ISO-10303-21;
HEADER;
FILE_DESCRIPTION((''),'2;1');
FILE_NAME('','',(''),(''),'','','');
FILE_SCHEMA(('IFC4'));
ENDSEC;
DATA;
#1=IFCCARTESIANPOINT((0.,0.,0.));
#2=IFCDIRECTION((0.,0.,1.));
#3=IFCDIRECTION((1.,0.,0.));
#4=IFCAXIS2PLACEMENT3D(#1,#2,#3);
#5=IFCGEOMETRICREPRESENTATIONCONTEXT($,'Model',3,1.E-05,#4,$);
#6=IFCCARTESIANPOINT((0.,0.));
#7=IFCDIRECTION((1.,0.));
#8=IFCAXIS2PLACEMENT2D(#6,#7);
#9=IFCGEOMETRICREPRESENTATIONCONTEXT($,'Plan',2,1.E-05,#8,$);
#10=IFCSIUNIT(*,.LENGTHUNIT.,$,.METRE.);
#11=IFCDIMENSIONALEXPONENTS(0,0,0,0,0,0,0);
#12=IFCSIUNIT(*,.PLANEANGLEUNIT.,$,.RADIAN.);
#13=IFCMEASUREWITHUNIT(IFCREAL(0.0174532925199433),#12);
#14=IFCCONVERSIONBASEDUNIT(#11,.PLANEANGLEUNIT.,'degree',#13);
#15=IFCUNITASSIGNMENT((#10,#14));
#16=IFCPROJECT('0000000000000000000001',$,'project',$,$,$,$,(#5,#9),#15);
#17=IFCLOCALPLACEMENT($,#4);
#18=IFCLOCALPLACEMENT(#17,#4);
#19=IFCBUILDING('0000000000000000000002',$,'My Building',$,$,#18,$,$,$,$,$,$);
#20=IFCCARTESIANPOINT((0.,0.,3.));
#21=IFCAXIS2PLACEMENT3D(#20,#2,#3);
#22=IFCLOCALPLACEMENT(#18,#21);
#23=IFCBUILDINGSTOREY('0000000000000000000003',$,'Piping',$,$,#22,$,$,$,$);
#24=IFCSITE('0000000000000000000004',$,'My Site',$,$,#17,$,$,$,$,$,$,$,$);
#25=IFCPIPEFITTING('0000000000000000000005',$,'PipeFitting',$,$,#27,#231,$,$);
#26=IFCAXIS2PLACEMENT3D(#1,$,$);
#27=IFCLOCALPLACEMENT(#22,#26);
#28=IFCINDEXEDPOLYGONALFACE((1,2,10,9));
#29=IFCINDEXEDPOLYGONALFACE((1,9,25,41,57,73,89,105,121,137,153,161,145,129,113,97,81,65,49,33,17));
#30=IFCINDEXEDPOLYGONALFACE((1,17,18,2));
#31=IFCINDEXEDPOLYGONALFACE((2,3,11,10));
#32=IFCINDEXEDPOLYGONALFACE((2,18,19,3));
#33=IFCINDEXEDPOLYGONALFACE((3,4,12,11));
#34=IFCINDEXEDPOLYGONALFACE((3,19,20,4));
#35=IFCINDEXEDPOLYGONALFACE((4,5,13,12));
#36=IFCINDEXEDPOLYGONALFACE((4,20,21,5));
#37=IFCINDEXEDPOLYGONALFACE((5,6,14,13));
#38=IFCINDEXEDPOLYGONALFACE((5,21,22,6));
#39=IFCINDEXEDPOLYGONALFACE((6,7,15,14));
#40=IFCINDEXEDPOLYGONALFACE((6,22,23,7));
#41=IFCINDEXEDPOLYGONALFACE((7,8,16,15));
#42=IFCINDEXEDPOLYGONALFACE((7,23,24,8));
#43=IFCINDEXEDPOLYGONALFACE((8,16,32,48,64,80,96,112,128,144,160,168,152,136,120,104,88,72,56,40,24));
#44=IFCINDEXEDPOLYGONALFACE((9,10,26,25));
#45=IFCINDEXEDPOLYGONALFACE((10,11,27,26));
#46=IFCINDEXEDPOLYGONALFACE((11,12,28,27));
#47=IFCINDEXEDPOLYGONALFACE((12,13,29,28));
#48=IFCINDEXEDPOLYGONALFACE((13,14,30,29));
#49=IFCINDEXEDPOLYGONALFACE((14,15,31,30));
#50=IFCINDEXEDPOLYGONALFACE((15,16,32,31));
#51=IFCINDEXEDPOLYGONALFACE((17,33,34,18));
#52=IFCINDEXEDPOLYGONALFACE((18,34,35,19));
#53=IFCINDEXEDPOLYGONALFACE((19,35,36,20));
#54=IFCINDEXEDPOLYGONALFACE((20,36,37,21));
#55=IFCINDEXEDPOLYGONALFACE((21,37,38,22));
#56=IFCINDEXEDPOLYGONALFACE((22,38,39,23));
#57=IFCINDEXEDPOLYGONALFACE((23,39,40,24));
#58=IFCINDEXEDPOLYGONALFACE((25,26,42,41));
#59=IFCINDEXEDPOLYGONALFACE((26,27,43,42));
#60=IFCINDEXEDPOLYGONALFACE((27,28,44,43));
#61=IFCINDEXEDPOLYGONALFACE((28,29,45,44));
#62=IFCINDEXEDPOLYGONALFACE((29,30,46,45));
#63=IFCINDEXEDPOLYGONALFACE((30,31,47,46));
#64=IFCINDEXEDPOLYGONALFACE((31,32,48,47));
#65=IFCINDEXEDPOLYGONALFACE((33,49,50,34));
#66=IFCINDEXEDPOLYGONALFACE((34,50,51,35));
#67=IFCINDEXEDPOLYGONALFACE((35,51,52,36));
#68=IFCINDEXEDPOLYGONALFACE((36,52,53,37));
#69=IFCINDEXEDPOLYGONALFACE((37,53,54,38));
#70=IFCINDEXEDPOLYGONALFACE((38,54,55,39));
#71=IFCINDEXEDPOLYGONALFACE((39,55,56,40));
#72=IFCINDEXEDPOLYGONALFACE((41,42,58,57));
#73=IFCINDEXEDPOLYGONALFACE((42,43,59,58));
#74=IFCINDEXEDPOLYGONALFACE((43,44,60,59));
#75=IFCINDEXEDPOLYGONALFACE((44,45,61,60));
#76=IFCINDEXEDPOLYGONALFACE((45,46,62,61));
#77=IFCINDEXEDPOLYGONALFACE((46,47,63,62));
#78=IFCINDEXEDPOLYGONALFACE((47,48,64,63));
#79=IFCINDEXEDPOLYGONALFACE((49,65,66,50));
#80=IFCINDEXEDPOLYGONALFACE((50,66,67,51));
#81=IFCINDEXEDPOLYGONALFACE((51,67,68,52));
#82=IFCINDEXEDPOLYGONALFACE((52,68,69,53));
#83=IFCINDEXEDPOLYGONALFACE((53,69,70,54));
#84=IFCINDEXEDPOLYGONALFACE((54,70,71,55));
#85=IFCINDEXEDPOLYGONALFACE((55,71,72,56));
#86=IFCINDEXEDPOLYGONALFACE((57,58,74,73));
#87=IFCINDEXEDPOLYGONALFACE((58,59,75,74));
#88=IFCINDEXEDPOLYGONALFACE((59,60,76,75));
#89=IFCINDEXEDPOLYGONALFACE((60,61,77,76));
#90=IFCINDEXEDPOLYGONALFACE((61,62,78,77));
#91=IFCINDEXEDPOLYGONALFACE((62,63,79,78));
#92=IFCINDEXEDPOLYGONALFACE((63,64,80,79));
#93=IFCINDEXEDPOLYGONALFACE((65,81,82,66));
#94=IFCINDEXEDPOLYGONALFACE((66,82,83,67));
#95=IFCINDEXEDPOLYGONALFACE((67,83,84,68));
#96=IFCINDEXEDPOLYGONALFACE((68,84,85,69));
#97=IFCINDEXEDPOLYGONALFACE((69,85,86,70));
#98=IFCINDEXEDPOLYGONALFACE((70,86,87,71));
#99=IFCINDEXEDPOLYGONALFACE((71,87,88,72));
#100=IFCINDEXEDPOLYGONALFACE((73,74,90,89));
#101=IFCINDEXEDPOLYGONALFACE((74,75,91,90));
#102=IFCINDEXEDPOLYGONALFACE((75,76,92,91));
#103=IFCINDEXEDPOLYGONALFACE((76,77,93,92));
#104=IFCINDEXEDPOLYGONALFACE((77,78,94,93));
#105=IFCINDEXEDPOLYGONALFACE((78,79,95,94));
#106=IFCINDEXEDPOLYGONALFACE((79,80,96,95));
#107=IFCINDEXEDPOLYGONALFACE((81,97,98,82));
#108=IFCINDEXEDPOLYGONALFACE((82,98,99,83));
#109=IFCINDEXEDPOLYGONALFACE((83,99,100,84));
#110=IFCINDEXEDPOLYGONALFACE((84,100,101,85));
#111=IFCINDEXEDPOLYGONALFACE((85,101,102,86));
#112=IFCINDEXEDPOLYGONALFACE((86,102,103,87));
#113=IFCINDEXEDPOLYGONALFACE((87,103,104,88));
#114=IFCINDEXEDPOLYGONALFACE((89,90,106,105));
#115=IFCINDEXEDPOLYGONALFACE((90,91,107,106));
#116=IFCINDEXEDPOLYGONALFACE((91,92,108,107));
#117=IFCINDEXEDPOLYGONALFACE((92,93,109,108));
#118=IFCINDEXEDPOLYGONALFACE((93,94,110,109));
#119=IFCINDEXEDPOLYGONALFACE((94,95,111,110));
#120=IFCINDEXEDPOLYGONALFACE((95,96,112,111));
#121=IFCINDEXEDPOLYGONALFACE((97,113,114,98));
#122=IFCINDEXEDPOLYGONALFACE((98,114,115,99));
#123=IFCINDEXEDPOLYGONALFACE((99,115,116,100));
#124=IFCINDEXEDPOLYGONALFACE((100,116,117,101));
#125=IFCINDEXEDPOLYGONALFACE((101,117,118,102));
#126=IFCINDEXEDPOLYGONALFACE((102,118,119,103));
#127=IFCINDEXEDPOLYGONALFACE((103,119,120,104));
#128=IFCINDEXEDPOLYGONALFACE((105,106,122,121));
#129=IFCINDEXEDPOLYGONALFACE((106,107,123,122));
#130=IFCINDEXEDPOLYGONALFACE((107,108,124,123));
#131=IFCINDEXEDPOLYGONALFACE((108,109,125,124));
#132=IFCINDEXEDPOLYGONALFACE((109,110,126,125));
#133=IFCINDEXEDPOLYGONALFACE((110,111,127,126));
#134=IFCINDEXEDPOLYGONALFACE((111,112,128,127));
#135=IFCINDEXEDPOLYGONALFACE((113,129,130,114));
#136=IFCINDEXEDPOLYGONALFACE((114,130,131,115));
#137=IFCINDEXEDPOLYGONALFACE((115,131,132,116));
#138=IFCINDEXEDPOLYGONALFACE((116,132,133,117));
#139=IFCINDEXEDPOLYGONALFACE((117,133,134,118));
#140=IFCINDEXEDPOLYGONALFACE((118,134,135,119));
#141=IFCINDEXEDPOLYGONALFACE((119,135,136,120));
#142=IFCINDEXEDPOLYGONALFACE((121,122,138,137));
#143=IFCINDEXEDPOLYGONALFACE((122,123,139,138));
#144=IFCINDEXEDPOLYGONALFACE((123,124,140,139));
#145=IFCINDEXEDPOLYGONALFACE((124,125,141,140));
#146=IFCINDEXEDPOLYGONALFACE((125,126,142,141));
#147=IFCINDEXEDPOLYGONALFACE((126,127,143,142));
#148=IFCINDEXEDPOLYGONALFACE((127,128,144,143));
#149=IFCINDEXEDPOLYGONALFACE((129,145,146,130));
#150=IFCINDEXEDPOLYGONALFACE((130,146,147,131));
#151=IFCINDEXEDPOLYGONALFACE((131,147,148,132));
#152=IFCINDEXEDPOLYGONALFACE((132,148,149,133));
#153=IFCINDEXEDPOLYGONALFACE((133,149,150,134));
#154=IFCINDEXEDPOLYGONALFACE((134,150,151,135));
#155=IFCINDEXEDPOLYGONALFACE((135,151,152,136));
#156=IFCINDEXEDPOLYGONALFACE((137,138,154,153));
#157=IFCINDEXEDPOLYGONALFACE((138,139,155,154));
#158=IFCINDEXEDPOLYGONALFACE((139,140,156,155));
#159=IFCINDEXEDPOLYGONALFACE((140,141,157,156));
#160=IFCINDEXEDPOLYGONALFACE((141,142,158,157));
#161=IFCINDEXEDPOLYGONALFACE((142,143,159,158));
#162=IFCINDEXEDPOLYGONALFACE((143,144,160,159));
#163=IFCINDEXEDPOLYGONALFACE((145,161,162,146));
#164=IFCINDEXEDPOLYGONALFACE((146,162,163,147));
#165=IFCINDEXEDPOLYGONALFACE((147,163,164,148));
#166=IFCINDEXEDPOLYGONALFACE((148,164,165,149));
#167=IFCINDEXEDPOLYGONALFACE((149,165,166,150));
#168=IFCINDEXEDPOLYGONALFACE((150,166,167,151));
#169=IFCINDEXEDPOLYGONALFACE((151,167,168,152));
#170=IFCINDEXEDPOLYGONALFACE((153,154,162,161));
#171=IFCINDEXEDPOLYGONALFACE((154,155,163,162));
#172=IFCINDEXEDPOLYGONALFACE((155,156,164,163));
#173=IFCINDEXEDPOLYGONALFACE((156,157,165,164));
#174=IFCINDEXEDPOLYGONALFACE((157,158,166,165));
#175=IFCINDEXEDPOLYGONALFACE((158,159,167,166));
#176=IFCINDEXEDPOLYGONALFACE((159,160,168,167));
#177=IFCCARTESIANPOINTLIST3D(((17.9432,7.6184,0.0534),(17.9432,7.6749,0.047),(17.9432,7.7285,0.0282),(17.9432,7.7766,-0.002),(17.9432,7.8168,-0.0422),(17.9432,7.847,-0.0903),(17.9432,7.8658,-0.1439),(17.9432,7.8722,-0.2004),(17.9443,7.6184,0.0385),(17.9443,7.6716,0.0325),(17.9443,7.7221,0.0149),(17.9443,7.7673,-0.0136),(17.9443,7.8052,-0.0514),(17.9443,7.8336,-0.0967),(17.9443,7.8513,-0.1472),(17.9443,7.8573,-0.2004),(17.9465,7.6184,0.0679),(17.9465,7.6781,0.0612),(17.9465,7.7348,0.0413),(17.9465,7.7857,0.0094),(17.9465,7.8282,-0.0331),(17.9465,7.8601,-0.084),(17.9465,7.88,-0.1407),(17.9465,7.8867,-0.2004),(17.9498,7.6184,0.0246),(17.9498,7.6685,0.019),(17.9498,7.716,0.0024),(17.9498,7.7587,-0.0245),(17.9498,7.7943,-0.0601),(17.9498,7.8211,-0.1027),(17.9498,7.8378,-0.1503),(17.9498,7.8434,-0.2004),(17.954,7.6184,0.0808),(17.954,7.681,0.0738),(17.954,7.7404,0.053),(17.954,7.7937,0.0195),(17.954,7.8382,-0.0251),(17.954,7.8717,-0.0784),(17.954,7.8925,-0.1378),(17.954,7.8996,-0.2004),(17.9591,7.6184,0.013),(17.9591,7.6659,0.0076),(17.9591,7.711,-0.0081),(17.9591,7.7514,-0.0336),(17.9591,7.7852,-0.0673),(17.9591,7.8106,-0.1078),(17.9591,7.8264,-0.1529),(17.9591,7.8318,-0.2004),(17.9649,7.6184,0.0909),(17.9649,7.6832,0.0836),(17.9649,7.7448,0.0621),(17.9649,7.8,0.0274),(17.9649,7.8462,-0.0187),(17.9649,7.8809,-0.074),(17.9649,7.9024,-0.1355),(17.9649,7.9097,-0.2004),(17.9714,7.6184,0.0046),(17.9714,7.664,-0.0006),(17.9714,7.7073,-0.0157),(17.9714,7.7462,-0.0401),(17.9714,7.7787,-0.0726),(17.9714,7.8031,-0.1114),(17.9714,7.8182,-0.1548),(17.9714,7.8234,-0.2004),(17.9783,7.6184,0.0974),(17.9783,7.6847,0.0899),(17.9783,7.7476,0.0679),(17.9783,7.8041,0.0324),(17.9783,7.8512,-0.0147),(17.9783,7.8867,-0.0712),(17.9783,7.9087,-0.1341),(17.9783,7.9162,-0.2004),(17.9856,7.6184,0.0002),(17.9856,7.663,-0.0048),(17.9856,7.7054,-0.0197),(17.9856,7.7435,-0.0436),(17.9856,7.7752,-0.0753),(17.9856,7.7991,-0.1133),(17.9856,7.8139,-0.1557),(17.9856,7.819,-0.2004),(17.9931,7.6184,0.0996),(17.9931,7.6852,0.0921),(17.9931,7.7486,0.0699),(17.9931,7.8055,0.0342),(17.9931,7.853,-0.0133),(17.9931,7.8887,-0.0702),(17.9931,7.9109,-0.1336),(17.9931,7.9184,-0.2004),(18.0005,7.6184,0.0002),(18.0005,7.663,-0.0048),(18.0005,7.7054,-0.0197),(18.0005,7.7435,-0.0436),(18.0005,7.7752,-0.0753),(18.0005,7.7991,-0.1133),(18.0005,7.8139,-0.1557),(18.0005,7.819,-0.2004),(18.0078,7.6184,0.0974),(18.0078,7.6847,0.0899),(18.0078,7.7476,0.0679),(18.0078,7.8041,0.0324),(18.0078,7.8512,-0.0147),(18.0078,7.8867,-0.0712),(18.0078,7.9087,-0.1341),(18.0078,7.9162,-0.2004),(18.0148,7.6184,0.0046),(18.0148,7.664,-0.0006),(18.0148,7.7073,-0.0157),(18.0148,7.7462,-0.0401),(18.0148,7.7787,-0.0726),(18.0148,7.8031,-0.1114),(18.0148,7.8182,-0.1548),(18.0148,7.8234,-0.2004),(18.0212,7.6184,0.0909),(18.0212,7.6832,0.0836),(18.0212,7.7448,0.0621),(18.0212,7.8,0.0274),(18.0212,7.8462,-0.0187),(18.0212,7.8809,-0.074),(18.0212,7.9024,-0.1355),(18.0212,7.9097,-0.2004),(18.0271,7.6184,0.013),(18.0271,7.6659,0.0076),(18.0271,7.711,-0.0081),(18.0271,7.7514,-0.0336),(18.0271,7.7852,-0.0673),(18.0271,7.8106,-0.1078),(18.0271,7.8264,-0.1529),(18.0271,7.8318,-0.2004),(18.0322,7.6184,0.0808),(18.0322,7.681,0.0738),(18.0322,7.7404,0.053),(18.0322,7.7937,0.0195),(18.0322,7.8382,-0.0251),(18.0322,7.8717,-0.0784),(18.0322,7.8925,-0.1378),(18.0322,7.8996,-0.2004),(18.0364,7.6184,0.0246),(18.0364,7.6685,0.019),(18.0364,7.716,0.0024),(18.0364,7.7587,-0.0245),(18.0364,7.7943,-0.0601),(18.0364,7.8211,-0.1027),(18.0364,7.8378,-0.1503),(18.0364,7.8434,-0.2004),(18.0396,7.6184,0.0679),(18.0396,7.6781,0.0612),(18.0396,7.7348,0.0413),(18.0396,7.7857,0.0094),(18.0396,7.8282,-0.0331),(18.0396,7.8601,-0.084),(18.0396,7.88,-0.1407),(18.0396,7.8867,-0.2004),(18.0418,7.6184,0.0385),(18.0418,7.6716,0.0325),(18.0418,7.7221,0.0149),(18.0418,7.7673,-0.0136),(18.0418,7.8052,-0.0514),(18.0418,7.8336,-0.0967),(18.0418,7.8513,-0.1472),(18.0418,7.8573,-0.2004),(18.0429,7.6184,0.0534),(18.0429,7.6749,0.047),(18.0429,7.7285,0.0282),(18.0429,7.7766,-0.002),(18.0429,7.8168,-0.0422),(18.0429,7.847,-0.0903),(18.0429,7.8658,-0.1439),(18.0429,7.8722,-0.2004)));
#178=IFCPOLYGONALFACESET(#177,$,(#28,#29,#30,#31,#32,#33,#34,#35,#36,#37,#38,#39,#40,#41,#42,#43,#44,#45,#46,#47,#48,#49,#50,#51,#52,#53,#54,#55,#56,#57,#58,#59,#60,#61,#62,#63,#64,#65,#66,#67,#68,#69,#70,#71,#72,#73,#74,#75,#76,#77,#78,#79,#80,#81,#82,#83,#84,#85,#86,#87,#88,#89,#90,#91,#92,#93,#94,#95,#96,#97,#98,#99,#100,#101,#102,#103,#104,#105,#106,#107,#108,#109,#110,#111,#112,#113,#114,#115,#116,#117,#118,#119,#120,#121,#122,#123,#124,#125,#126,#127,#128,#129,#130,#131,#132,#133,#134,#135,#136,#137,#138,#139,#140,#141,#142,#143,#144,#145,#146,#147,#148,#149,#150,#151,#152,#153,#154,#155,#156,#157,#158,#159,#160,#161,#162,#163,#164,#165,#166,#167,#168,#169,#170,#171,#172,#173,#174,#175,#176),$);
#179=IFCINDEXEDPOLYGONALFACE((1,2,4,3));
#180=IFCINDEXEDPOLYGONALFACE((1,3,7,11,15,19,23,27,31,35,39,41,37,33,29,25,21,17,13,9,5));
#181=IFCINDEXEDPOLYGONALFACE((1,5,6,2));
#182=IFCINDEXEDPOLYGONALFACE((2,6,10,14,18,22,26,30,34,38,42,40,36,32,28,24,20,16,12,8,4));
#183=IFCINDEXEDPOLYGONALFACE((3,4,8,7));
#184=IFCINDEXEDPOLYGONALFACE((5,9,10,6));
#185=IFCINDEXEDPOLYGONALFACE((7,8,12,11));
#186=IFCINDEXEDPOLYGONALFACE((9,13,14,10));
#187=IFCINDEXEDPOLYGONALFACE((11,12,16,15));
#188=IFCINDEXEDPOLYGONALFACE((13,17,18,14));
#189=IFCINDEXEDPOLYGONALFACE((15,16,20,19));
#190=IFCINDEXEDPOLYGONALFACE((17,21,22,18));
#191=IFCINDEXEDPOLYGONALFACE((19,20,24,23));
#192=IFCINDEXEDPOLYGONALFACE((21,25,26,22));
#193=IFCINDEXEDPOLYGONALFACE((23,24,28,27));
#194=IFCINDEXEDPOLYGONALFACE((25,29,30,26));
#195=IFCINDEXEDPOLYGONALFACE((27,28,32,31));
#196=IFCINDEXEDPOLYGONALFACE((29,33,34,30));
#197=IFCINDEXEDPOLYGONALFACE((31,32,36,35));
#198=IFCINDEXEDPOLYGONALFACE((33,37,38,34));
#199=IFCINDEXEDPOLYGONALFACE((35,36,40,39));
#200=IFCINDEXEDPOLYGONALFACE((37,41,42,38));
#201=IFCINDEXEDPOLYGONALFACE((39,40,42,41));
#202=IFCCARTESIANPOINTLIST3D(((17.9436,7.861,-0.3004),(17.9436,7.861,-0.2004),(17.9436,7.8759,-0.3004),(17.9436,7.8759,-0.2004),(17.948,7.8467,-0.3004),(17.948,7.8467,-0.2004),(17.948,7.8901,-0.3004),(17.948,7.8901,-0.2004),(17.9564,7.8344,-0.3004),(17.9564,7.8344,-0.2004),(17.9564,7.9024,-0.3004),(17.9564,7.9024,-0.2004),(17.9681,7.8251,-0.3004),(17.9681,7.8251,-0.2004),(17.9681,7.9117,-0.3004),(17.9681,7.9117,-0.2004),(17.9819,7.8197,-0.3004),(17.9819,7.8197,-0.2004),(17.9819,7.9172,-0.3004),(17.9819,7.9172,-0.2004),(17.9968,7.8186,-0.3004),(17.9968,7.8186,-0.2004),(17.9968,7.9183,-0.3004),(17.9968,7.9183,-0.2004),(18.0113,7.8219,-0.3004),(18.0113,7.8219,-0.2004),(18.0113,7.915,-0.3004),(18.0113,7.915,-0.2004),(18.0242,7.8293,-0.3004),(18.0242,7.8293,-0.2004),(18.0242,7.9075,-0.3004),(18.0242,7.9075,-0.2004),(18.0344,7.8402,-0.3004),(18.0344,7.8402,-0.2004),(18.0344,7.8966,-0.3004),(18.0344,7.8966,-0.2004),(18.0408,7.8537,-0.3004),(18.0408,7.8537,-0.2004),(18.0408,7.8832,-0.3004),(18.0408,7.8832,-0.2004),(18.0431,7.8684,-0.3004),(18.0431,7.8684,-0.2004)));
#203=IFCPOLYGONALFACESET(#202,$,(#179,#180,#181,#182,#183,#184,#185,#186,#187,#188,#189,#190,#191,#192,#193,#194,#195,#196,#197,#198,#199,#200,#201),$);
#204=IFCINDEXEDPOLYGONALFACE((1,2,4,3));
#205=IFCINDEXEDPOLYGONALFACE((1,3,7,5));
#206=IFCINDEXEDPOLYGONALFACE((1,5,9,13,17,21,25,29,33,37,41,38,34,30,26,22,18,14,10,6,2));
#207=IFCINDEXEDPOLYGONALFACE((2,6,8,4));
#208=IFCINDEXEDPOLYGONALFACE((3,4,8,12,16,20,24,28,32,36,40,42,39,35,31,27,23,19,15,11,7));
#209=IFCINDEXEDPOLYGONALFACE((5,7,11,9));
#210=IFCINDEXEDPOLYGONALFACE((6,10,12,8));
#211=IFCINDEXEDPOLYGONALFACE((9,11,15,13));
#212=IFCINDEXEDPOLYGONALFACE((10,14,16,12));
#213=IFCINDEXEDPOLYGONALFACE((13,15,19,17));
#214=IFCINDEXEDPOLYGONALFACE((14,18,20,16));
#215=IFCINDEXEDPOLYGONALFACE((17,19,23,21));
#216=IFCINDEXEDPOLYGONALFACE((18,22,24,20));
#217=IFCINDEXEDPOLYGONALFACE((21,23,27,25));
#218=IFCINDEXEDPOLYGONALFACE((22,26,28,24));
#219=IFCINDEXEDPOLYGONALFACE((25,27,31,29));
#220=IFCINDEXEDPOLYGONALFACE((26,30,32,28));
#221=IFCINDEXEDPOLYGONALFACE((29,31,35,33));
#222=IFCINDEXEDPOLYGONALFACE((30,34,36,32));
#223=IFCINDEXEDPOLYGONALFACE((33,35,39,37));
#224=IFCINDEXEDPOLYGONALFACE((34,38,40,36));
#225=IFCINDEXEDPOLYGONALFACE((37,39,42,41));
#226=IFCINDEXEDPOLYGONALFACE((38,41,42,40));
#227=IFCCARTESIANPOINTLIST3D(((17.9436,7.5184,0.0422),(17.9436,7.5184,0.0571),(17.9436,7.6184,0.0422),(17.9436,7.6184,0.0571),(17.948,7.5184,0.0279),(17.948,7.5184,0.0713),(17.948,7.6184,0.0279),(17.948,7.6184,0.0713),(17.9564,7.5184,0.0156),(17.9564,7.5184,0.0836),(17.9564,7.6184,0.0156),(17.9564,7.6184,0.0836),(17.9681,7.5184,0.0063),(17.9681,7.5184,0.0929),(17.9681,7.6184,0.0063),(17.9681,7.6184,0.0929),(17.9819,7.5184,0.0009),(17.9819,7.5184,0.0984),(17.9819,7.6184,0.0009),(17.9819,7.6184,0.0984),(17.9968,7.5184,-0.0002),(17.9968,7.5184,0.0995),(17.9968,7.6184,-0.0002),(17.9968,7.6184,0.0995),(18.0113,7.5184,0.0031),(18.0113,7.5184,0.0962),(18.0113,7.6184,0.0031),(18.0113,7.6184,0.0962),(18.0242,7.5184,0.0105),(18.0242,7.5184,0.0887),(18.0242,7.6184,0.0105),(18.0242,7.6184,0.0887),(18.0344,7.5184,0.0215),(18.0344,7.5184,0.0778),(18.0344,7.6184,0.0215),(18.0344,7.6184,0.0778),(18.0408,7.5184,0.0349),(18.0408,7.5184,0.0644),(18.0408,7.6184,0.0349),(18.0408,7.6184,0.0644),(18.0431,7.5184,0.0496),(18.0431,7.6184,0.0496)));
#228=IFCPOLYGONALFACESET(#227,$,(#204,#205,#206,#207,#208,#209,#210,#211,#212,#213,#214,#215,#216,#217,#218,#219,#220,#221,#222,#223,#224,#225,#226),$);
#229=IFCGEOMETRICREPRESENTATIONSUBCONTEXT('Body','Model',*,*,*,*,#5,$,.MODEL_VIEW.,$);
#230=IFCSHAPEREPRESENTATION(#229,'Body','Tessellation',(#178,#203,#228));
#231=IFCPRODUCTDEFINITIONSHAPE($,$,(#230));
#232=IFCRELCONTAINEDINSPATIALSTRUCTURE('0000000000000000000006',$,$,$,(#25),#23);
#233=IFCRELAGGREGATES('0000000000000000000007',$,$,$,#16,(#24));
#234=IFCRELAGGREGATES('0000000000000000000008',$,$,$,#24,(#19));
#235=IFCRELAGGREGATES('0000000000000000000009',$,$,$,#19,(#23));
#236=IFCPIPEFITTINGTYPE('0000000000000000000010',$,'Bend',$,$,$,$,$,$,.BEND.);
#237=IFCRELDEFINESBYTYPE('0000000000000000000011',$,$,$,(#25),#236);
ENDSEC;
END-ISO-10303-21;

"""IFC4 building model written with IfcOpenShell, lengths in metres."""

from ifc_helpers import new_model, entity, si_unit, converted_unit, frame, origin_with_axes, origin_2d_with_axis, place, context, subcontext, project, spatial, circle, extrude, source, transform, mapped, type_object, type_shapes, element, save


model = new_model("IFC4")

# Units and contexts
model_context = context("Model", 3, precision=1e-05, world=origin_with_axes())
plan_context = context("Plan", 2, precision=1e-05, world=origin_2d_with_axis())
body_context = subcontext(model_context, "Body", "Model", "MODEL_VIEW")
ifc_project = project(units=[si_unit("LENGTHUNIT", "METRE"), converted_unit("PLANEANGLEUNIT", "degree", entity("IfcReal", 0.0174532925199433), si_unit("PLANEANGLEUNIT", "RADIAN"), dimensions=[0, 0, 0, 0, 0, 0, 0])], contexts=[model_context, plan_context])

# Site, building, storey
site_placement = place(None, origin_with_axes())
site = spatial("IfcSite", under=ifc_project, at=site_placement, Name="My Site")
building_placement = place(site_placement, origin_with_axes())
building = spatial("IfcBuilding", under=site, at=building_placement, Name="My Building")
storey_placement = place(building_placement, frame((0.0, 0.0, 3.0), z_axis=(0.0, 0.0, 1.0), x_axis=(1.0, 0.0, 0.0)))
storey = spatial("IfcBuildingStorey", under=building, at=storey_placement, Name="Piping")

# Pipe fitting
pipe_fitting_type = type_object("IfcPipeFittingType", Name="Bend", PredefinedType="BEND")
shared_shape = source(origin_with_axes(), body_context, "Body", "SolidModel", [
    entity("IfcSweptDiskSolid", entity("IfcIndexedPolyCurve", entity("IfcCartesianPointList3D", [[0.0, 0.0, -0.1], [0.0, 0.0732, -0.2768], [0.0, 0.25, -0.35]]), [entity("IfcArcIndex", [1, 2, 3])]), 0.05),
    extrude(circle(Radius=0.05), origin_with_axes(), (0.0, 0.0, -1.0), 0.1),
    extrude(circle(Radius=0.05), frame((0.0, 0.25, -0.35), z_axis=(0.0, 1.0, 0.000007), x_axis=(1.0, 0.0, 0.0)), (0.0, 0.0, 1.0), 0.1),
])
type_shapes(pipe_fitting_type, [shared_shape])
for number, where, z_axis, x_axis, name in (
    (1, (17.9931, 7.8684, -0.3004), (0.0, 0.0, -1.0), (1.0, 0.0, 0.0), "PipeFitting"),
):
    element("IfcPipeFitting", number, at=place(storey_placement, frame(where, z_axis=z_axis, x_axis=x_axis)), inside=storey, type_object=pipe_fitting_type, Name=name, context=body_context, shape_type="MappedRepresentation", body=[
        mapped(shared_shape, transform((0.0, 0.0, 0.0), x_axis=(1.0, 0.0, 0.0), y_axis=(0.0, 1.0, 0.0), z_axis=(0.0, 0.0, 1.0), scale=1.0)),
    ])

save(model, "model.ifc")
